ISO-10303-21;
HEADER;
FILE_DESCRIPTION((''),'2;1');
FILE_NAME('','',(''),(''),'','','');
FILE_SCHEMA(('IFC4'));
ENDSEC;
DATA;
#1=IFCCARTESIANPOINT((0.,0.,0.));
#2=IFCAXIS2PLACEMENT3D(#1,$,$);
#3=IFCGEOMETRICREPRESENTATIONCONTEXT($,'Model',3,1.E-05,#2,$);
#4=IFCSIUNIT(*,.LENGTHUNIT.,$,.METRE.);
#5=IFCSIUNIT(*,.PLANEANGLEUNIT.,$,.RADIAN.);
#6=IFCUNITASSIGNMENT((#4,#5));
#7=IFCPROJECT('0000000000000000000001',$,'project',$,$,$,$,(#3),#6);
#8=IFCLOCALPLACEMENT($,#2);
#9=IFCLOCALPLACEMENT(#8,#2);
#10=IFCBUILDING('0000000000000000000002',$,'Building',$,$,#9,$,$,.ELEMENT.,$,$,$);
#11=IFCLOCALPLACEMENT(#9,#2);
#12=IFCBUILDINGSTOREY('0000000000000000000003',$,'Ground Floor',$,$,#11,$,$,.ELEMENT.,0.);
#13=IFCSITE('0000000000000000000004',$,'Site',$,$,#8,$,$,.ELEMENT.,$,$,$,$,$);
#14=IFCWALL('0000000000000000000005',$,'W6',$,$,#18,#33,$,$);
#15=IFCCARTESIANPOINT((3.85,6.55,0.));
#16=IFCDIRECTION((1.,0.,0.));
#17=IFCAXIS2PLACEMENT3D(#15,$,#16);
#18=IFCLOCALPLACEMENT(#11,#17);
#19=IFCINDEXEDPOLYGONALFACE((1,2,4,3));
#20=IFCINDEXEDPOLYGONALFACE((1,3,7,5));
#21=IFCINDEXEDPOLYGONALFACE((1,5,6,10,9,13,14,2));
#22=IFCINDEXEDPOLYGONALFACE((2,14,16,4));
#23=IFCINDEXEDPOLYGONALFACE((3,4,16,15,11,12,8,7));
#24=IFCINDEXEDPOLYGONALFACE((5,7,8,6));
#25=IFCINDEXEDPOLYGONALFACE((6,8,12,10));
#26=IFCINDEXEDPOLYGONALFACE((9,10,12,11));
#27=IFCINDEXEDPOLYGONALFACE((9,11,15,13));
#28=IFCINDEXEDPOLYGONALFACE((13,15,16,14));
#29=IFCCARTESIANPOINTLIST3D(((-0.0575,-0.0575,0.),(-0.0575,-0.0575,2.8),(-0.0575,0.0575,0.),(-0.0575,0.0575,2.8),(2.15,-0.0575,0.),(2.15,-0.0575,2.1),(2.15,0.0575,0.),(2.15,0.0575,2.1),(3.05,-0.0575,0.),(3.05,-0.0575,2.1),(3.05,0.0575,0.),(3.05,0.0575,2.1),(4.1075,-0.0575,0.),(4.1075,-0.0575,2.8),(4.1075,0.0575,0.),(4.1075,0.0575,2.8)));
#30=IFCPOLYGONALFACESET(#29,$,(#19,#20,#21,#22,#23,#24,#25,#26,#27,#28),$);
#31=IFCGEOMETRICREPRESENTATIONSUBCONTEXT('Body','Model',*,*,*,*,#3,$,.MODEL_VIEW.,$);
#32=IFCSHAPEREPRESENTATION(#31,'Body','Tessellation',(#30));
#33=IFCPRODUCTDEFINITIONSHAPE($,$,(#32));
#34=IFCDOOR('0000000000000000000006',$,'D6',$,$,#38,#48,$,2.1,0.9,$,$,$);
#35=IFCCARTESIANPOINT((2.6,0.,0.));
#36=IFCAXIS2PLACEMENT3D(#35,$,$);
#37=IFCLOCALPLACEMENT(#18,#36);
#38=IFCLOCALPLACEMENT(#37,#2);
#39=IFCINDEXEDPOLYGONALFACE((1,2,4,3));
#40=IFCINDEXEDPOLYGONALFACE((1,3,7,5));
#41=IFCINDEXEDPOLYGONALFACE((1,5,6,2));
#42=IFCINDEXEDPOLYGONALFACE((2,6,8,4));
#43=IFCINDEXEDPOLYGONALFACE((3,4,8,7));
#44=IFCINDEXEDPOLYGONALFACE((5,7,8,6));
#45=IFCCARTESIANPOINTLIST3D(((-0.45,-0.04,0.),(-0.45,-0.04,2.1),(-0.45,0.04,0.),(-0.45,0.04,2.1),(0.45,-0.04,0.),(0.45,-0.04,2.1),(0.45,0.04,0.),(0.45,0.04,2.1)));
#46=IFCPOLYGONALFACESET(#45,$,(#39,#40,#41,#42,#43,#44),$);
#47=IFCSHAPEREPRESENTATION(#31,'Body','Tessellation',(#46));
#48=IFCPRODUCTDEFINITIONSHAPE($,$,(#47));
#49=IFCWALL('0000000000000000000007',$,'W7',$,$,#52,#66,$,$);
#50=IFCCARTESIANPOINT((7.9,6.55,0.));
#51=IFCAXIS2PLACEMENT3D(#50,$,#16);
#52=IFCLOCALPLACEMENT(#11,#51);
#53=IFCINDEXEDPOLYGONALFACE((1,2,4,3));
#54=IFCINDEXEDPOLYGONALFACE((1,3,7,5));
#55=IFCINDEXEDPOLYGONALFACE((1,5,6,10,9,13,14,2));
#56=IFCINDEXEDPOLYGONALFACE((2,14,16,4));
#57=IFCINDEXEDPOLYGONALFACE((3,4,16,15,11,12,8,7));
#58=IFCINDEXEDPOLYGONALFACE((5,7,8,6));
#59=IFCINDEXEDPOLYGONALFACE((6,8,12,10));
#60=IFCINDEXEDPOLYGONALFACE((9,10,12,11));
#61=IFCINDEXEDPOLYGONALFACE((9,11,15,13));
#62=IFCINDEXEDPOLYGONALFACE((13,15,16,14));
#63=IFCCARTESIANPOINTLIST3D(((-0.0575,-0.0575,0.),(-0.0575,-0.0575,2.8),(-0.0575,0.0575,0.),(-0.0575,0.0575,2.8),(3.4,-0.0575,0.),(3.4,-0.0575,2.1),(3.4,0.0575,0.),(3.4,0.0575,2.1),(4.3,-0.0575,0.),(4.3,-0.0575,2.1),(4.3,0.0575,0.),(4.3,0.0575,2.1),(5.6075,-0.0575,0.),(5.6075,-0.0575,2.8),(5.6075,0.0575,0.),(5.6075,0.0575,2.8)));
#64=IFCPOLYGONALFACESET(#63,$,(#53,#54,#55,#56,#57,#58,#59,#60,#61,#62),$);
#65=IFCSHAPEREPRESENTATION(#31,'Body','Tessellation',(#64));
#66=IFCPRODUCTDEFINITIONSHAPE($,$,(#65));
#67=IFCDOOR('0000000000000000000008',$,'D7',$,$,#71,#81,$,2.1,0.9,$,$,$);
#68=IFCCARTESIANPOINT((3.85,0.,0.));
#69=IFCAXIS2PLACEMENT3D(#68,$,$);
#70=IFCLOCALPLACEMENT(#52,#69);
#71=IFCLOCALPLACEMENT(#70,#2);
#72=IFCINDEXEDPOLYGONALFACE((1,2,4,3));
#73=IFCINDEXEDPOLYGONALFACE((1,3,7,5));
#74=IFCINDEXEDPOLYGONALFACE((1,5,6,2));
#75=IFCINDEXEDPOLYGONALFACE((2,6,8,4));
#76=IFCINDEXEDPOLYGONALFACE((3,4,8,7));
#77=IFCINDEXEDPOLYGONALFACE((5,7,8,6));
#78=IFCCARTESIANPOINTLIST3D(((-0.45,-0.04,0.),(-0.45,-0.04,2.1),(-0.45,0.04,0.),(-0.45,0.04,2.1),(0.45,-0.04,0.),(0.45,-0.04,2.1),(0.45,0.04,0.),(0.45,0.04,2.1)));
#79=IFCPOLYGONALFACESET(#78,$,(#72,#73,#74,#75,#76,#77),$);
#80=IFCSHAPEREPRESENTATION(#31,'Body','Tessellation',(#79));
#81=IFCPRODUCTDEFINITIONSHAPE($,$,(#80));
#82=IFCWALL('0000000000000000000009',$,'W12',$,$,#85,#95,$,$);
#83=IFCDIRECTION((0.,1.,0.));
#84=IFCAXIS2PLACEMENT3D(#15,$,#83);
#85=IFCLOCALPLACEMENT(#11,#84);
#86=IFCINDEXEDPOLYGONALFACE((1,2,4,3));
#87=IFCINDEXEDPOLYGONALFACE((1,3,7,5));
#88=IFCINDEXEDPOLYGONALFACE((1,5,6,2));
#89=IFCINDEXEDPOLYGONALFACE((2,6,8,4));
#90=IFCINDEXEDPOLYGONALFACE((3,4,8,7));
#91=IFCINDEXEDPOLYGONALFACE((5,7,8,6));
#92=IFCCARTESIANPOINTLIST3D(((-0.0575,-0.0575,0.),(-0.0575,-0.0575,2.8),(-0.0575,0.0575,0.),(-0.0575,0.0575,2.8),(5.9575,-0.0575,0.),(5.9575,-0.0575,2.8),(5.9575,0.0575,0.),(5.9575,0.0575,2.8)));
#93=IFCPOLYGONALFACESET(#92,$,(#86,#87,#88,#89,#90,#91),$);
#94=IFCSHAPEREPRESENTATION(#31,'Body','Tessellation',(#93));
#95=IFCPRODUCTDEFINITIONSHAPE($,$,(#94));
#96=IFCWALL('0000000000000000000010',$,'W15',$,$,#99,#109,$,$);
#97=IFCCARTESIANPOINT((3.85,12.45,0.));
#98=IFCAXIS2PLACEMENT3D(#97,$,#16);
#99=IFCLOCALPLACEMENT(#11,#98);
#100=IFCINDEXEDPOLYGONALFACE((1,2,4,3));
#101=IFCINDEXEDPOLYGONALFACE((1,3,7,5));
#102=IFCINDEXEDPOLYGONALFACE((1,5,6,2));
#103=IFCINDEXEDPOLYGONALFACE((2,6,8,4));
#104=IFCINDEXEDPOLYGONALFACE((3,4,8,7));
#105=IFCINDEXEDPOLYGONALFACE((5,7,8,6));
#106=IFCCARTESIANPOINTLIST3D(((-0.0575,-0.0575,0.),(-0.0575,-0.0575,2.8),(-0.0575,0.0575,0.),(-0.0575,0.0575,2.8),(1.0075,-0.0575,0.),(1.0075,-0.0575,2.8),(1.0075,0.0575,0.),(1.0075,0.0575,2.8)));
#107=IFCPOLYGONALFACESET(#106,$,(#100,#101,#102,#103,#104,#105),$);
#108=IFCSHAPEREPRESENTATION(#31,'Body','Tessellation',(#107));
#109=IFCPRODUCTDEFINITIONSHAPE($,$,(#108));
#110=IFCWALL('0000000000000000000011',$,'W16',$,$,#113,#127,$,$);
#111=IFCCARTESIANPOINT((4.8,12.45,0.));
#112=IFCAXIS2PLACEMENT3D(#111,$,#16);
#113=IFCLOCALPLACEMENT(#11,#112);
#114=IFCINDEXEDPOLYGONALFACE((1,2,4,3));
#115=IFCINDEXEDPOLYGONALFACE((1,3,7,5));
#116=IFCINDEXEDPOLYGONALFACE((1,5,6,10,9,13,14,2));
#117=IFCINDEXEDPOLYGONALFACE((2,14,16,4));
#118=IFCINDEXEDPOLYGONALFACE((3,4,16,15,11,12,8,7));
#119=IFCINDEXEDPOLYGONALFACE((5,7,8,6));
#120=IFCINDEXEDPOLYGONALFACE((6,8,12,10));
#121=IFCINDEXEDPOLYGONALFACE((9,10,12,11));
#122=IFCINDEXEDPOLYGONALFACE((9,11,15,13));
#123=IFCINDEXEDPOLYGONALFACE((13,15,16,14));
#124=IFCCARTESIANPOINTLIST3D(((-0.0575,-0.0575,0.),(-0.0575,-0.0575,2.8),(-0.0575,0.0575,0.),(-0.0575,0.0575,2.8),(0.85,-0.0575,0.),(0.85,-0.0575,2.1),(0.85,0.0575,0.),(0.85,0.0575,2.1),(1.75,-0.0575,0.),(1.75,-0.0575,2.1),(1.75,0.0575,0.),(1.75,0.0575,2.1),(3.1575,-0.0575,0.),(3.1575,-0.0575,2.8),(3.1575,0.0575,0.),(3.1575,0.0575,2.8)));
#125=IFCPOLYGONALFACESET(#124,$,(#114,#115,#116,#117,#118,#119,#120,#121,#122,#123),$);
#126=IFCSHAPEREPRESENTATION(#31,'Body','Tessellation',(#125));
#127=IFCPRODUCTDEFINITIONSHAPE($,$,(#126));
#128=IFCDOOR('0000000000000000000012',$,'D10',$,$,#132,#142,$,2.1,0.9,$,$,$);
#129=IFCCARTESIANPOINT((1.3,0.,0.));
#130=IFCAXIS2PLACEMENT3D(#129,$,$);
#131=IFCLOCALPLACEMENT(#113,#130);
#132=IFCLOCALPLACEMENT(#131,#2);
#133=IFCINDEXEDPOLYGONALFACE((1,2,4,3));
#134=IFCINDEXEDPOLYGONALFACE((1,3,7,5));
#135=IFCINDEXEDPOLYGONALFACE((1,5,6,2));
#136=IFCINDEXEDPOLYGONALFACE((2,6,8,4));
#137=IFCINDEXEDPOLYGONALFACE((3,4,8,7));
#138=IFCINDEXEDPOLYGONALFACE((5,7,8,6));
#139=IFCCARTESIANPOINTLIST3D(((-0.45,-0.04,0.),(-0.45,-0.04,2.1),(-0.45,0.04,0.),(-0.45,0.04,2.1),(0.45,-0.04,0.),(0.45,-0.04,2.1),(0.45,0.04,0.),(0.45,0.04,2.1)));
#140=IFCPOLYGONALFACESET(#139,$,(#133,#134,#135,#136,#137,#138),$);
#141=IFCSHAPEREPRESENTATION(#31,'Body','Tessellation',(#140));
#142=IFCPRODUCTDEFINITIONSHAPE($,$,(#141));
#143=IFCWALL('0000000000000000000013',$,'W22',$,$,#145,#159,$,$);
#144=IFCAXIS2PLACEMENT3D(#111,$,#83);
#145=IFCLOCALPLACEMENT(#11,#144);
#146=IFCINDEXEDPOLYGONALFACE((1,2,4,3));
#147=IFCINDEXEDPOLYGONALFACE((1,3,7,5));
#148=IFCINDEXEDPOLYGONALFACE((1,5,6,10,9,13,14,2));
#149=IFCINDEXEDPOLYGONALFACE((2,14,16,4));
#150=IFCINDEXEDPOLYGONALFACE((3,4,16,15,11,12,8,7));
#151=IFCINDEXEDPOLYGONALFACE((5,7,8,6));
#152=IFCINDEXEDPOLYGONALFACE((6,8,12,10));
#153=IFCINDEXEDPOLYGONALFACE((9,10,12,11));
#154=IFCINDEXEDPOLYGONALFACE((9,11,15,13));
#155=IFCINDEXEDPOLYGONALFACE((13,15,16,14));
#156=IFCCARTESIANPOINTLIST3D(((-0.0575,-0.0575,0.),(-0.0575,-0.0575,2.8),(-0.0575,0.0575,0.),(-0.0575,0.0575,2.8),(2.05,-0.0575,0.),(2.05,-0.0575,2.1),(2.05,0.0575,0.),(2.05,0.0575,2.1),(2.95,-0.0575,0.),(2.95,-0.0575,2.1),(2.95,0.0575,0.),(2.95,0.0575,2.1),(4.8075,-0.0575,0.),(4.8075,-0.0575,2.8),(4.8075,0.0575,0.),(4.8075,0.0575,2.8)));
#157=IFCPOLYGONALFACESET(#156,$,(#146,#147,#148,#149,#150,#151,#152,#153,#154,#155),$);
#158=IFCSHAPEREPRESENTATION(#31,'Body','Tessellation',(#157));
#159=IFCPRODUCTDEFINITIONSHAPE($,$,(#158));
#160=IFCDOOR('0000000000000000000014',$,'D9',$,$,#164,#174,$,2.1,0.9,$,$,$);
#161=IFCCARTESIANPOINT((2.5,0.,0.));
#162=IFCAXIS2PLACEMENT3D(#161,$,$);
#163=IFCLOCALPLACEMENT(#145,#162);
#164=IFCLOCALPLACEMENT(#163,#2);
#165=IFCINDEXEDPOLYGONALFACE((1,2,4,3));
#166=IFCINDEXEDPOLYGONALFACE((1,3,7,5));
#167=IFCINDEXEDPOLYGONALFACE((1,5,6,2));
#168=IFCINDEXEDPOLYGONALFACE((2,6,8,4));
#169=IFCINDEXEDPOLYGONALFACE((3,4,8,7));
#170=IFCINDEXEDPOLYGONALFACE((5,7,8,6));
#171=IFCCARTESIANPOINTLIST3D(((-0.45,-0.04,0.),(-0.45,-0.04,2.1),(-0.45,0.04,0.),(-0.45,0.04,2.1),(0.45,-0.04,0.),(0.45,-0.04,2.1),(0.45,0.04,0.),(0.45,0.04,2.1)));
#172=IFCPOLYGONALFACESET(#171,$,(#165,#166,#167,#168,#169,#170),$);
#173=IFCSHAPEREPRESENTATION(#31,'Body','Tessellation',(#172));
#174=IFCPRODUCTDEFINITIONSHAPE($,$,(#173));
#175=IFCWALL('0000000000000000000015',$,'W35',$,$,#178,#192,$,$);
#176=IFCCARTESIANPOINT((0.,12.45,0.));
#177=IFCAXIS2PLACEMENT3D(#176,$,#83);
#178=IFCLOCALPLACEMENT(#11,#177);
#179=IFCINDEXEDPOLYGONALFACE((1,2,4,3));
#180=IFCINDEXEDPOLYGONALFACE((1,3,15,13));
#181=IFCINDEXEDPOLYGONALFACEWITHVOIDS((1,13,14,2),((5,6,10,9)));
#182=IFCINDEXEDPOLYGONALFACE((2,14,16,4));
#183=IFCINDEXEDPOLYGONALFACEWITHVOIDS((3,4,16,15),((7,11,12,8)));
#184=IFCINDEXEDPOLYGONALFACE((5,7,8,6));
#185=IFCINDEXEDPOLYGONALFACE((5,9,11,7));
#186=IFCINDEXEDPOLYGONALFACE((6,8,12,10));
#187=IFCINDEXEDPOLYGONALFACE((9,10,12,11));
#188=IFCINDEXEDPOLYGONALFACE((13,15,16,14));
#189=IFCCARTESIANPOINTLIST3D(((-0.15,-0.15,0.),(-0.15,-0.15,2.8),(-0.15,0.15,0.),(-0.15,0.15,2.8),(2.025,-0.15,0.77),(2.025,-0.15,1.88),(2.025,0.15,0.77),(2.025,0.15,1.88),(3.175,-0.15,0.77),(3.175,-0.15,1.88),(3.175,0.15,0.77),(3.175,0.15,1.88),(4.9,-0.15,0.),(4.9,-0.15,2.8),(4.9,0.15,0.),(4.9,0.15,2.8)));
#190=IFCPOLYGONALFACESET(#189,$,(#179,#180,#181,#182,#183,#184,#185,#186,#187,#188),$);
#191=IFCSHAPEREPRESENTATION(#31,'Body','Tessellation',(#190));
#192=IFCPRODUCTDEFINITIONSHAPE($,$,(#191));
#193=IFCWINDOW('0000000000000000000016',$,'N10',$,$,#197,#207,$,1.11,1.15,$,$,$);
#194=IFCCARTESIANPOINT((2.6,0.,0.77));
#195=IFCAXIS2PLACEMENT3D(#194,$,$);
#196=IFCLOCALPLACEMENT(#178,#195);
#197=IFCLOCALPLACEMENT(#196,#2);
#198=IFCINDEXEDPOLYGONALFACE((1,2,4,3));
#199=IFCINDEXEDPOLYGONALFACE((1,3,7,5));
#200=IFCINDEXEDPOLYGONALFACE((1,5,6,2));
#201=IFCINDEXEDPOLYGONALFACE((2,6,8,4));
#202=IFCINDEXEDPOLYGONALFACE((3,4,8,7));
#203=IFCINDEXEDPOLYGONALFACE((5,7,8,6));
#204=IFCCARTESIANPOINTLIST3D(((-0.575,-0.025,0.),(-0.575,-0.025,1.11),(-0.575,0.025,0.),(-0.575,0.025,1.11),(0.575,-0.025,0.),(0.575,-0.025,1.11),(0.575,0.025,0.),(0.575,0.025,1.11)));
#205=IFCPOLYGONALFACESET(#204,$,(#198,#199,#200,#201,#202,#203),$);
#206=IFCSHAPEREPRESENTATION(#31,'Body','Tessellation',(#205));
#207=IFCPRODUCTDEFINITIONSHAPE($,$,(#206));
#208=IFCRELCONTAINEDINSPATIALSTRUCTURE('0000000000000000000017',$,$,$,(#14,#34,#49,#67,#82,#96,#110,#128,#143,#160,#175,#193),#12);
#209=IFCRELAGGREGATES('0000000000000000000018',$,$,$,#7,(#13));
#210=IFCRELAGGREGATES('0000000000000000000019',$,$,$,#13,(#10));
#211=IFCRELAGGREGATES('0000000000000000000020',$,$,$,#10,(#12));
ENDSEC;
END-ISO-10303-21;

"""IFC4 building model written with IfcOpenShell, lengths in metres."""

from ifc_helpers import new_model, si_unit, frame, frame_2d, origin, origin_2d, place, context, subcontext, project, spatial, rectangle, extrude, element, fill, save


model = new_model("IFC4")

# Units and contexts
model_context = context("Model", 3, precision=1e-05, world=origin())
body_context = subcontext(model_context, "Body", "Model", "MODEL_VIEW")
ifc_project = project(units=[si_unit("LENGTHUNIT", "METRE"), si_unit("PLANEANGLEUNIT", "RADIAN")], contexts=[model_context])

# Site, building, storey
site_placement = place(None, origin())
site = spatial("IfcSite", under=ifc_project, at=site_placement, Name="Site", CompositionType="ELEMENT")
building_placement = place(site_placement, origin())
building = spatial("IfcBuilding", under=site, at=building_placement, Name="Building", CompositionType="ELEMENT")
storey_placement = place(building_placement, origin())
storey = spatial("IfcBuildingStorey", under=building, at=storey_placement, Name="Ground Floor", CompositionType="ELEMENT", Elevation=0.0)

# Walls, openings, doors
wall_1_placement = place(storey_placement, frame((3.85, 6.55, 0.0), x_axis=(1.0, 0.0, 0.0)))
wall_1 = element("IfcWall", 1, at=wall_1_placement, inside=storey, Name="W6", context=body_context, shape_type="SweptSolid", body=[
    extrude(rectangle(XDim=4.165, YDim=0.115, at=frame_2d((2.025, 0.0))), origin(), (0.0, 0.0, 1.0), 2.8),
])
opening_1_placement = place(wall_1_placement, frame((2.6, 0.0, 0.0)))
opening_1 = element("IfcOpeningElement", 2, at=opening_1_placement, cuts=wall_1, context=body_context, shape_type="SweptSolid", body=[
    extrude(rectangle(XDim=0.9, YDim=0.215, at=origin_2d()), origin(), (0.0, 0.0, 1.0), 2.1),
])
door_1_placement = place(opening_1_placement, origin())
door_1 = element("IfcDoor", 3, at=door_1_placement, inside=storey, Name="D6", OverallHeight=2.1, OverallWidth=0.9, context=body_context, shape_type="SweptSolid", body=[
    extrude(rectangle(XDim=0.9, YDim=0.08, at=origin_2d()), origin(), (0.0, 0.0, 1.0), 2.1),
])
fill(opening_1, door_1)
wall_2_placement = place(storey_placement, frame((7.9, 6.55, 0.0), x_axis=(1.0, 0.0, 0.0)))
wall_2 = element("IfcWall", 4, at=wall_2_placement, inside=storey, Name="W7", context=body_context, shape_type="SweptSolid", body=[
    extrude(rectangle(XDim=5.665, YDim=0.115, at=frame_2d((2.775, 0.0))), origin(), (0.0, 0.0, 1.0), 2.8),
])
opening_2_placement = place(wall_2_placement, frame((3.85, 0.0, 0.0)))
opening_2 = element("IfcOpeningElement", 5, at=opening_2_placement, cuts=wall_2, context=body_context, shape_type="SweptSolid", body=[
    extrude(rectangle(XDim=0.9, YDim=0.215, at=origin_2d()), origin(), (0.0, 0.0, 1.0), 2.1),
])
door_2_placement = place(opening_2_placement, origin())
door_2 = element("IfcDoor", 6, at=door_2_placement, inside=storey, Name="D7", OverallHeight=2.1, OverallWidth=0.9, context=body_context, shape_type="SweptSolid", body=[
    extrude(rectangle(XDim=0.9, YDim=0.08, at=origin_2d()), origin(), (0.0, 0.0, 1.0), 2.1),
])
fill(opening_2, door_2)

# Walls
wall_3_placement = place(storey_placement, frame((3.85, 6.55, 0.0), x_axis=(0.0, 1.0, 0.0)))
element("IfcWall", 7, at=wall_3_placement, inside=storey, Name="W12", context=body_context, shape_type="SweptSolid", body=[
    extrude(rectangle(XDim=6.015, YDim=0.115, at=frame_2d((2.95, 0.0))), origin(), (0.0, 0.0, 1.0), 2.8),
])
wall_4_placement = place(storey_placement, frame((3.85, 12.45, 0.0), x_axis=(1.0, 0.0, 0.0)))
element("IfcWall", 8, at=wall_4_placement, inside=storey, Name="W15", context=body_context, shape_type="SweptSolid", body=[
    extrude(rectangle(XDim=1.065, YDim=0.115, at=frame_2d((0.475, 0.0))), origin(), (0.0, 0.0, 1.0), 2.8),
])

# Walls, openings, doors
wall_5_placement = place(storey_placement, frame((4.8, 12.45, 0.0), x_axis=(1.0, 0.0, 0.0)))
wall_5 = element("IfcWall", 9, at=wall_5_placement, inside=storey, Name="W16", context=body_context, shape_type="SweptSolid", body=[
    extrude(rectangle(XDim=3.215, YDim=0.115, at=frame_2d((1.55, 0.0))), origin(), (0.0, 0.0, 1.0), 2.8),
])
opening_3_placement = place(wall_5_placement, frame((1.3, 0.0, 0.0)))
opening_3 = element("IfcOpeningElement", 10, at=opening_3_placement, cuts=wall_5, context=body_context, shape_type="SweptSolid", body=[
    extrude(rectangle(XDim=0.9, YDim=0.215, at=origin_2d()), origin(), (0.0, 0.0, 1.0), 2.1),
])
door_3_placement = place(opening_3_placement, origin())
door_3 = element("IfcDoor", 11, at=door_3_placement, inside=storey, Name="D10", OverallHeight=2.1, OverallWidth=0.9, context=body_context, shape_type="SweptSolid", body=[
    extrude(rectangle(XDim=0.9, YDim=0.08, at=origin_2d()), origin(), (0.0, 0.0, 1.0), 2.1),
])
fill(opening_3, door_3)
wall_6_placement = place(storey_placement, frame((4.8, 12.45, 0.0), x_axis=(0.0, 1.0, 0.0)))
wall_6 = element("IfcWall", 12, at=wall_6_placement, inside=storey, Name="W22", context=body_context, shape_type="SweptSolid", body=[
    extrude(rectangle(XDim=4.865, YDim=0.115, at=frame_2d((2.375, 0.0))), origin(), (0.0, 0.0, 1.0), 2.8),
])
opening_4_placement = place(wall_6_placement, frame((2.5, 0.0, 0.0)))
opening_4 = element("IfcOpeningElement", 13, at=opening_4_placement, cuts=wall_6, context=body_context, shape_type="SweptSolid", body=[
    extrude(rectangle(XDim=0.9, YDim=0.215, at=origin_2d()), origin(), (0.0, 0.0, 1.0), 2.1),
])
door_4_placement = place(opening_4_placement, origin())
door_4 = element("IfcDoor", 14, at=door_4_placement, inside=storey, Name="D9", OverallHeight=2.1, OverallWidth=0.9, context=body_context, shape_type="SweptSolid", body=[
    extrude(rectangle(XDim=0.9, YDim=0.08, at=origin_2d()), origin(), (0.0, 0.0, 1.0), 2.1),
])
fill(opening_4, door_4)

# Wall, opening, window
wall_7_placement = place(storey_placement, frame((0.0, 12.45, 0.0), x_axis=(0.0, 1.0, 0.0)))
wall_7 = element("IfcWall", 15, at=wall_7_placement, inside=storey, Name="W35", context=body_context, shape_type="SweptSolid", body=[
    extrude(rectangle(XDim=5.05, YDim=0.3, at=frame_2d((2.375, 0.0))), origin(), (0.0, 0.0, 1.0), 2.8),
])
opening_5_placement = place(wall_7_placement, frame((2.6, 0.0, 0.77)))
opening_5 = element("IfcOpeningElement", 16, at=opening_5_placement, cuts=wall_7, context=body_context, shape_type="SweptSolid", body=[
    extrude(rectangle(XDim=1.15, YDim=0.4, at=origin_2d()), origin(), (0.0, 0.0, 1.0), 1.11),
])
window_1_placement = place(opening_5_placement, origin())
window_1 = element("IfcWindow", 17, at=window_1_placement, inside=storey, Name="N10", OverallHeight=1.11, OverallWidth=1.15, context=body_context, shape_type="SweptSolid", body=[
    extrude(rectangle(XDim=1.15, YDim=0.05, at=origin_2d()), origin(), (0.0, 0.0, 1.0), 1.11),
])
fill(opening_5, window_1)

save(model, "model.ifc")
